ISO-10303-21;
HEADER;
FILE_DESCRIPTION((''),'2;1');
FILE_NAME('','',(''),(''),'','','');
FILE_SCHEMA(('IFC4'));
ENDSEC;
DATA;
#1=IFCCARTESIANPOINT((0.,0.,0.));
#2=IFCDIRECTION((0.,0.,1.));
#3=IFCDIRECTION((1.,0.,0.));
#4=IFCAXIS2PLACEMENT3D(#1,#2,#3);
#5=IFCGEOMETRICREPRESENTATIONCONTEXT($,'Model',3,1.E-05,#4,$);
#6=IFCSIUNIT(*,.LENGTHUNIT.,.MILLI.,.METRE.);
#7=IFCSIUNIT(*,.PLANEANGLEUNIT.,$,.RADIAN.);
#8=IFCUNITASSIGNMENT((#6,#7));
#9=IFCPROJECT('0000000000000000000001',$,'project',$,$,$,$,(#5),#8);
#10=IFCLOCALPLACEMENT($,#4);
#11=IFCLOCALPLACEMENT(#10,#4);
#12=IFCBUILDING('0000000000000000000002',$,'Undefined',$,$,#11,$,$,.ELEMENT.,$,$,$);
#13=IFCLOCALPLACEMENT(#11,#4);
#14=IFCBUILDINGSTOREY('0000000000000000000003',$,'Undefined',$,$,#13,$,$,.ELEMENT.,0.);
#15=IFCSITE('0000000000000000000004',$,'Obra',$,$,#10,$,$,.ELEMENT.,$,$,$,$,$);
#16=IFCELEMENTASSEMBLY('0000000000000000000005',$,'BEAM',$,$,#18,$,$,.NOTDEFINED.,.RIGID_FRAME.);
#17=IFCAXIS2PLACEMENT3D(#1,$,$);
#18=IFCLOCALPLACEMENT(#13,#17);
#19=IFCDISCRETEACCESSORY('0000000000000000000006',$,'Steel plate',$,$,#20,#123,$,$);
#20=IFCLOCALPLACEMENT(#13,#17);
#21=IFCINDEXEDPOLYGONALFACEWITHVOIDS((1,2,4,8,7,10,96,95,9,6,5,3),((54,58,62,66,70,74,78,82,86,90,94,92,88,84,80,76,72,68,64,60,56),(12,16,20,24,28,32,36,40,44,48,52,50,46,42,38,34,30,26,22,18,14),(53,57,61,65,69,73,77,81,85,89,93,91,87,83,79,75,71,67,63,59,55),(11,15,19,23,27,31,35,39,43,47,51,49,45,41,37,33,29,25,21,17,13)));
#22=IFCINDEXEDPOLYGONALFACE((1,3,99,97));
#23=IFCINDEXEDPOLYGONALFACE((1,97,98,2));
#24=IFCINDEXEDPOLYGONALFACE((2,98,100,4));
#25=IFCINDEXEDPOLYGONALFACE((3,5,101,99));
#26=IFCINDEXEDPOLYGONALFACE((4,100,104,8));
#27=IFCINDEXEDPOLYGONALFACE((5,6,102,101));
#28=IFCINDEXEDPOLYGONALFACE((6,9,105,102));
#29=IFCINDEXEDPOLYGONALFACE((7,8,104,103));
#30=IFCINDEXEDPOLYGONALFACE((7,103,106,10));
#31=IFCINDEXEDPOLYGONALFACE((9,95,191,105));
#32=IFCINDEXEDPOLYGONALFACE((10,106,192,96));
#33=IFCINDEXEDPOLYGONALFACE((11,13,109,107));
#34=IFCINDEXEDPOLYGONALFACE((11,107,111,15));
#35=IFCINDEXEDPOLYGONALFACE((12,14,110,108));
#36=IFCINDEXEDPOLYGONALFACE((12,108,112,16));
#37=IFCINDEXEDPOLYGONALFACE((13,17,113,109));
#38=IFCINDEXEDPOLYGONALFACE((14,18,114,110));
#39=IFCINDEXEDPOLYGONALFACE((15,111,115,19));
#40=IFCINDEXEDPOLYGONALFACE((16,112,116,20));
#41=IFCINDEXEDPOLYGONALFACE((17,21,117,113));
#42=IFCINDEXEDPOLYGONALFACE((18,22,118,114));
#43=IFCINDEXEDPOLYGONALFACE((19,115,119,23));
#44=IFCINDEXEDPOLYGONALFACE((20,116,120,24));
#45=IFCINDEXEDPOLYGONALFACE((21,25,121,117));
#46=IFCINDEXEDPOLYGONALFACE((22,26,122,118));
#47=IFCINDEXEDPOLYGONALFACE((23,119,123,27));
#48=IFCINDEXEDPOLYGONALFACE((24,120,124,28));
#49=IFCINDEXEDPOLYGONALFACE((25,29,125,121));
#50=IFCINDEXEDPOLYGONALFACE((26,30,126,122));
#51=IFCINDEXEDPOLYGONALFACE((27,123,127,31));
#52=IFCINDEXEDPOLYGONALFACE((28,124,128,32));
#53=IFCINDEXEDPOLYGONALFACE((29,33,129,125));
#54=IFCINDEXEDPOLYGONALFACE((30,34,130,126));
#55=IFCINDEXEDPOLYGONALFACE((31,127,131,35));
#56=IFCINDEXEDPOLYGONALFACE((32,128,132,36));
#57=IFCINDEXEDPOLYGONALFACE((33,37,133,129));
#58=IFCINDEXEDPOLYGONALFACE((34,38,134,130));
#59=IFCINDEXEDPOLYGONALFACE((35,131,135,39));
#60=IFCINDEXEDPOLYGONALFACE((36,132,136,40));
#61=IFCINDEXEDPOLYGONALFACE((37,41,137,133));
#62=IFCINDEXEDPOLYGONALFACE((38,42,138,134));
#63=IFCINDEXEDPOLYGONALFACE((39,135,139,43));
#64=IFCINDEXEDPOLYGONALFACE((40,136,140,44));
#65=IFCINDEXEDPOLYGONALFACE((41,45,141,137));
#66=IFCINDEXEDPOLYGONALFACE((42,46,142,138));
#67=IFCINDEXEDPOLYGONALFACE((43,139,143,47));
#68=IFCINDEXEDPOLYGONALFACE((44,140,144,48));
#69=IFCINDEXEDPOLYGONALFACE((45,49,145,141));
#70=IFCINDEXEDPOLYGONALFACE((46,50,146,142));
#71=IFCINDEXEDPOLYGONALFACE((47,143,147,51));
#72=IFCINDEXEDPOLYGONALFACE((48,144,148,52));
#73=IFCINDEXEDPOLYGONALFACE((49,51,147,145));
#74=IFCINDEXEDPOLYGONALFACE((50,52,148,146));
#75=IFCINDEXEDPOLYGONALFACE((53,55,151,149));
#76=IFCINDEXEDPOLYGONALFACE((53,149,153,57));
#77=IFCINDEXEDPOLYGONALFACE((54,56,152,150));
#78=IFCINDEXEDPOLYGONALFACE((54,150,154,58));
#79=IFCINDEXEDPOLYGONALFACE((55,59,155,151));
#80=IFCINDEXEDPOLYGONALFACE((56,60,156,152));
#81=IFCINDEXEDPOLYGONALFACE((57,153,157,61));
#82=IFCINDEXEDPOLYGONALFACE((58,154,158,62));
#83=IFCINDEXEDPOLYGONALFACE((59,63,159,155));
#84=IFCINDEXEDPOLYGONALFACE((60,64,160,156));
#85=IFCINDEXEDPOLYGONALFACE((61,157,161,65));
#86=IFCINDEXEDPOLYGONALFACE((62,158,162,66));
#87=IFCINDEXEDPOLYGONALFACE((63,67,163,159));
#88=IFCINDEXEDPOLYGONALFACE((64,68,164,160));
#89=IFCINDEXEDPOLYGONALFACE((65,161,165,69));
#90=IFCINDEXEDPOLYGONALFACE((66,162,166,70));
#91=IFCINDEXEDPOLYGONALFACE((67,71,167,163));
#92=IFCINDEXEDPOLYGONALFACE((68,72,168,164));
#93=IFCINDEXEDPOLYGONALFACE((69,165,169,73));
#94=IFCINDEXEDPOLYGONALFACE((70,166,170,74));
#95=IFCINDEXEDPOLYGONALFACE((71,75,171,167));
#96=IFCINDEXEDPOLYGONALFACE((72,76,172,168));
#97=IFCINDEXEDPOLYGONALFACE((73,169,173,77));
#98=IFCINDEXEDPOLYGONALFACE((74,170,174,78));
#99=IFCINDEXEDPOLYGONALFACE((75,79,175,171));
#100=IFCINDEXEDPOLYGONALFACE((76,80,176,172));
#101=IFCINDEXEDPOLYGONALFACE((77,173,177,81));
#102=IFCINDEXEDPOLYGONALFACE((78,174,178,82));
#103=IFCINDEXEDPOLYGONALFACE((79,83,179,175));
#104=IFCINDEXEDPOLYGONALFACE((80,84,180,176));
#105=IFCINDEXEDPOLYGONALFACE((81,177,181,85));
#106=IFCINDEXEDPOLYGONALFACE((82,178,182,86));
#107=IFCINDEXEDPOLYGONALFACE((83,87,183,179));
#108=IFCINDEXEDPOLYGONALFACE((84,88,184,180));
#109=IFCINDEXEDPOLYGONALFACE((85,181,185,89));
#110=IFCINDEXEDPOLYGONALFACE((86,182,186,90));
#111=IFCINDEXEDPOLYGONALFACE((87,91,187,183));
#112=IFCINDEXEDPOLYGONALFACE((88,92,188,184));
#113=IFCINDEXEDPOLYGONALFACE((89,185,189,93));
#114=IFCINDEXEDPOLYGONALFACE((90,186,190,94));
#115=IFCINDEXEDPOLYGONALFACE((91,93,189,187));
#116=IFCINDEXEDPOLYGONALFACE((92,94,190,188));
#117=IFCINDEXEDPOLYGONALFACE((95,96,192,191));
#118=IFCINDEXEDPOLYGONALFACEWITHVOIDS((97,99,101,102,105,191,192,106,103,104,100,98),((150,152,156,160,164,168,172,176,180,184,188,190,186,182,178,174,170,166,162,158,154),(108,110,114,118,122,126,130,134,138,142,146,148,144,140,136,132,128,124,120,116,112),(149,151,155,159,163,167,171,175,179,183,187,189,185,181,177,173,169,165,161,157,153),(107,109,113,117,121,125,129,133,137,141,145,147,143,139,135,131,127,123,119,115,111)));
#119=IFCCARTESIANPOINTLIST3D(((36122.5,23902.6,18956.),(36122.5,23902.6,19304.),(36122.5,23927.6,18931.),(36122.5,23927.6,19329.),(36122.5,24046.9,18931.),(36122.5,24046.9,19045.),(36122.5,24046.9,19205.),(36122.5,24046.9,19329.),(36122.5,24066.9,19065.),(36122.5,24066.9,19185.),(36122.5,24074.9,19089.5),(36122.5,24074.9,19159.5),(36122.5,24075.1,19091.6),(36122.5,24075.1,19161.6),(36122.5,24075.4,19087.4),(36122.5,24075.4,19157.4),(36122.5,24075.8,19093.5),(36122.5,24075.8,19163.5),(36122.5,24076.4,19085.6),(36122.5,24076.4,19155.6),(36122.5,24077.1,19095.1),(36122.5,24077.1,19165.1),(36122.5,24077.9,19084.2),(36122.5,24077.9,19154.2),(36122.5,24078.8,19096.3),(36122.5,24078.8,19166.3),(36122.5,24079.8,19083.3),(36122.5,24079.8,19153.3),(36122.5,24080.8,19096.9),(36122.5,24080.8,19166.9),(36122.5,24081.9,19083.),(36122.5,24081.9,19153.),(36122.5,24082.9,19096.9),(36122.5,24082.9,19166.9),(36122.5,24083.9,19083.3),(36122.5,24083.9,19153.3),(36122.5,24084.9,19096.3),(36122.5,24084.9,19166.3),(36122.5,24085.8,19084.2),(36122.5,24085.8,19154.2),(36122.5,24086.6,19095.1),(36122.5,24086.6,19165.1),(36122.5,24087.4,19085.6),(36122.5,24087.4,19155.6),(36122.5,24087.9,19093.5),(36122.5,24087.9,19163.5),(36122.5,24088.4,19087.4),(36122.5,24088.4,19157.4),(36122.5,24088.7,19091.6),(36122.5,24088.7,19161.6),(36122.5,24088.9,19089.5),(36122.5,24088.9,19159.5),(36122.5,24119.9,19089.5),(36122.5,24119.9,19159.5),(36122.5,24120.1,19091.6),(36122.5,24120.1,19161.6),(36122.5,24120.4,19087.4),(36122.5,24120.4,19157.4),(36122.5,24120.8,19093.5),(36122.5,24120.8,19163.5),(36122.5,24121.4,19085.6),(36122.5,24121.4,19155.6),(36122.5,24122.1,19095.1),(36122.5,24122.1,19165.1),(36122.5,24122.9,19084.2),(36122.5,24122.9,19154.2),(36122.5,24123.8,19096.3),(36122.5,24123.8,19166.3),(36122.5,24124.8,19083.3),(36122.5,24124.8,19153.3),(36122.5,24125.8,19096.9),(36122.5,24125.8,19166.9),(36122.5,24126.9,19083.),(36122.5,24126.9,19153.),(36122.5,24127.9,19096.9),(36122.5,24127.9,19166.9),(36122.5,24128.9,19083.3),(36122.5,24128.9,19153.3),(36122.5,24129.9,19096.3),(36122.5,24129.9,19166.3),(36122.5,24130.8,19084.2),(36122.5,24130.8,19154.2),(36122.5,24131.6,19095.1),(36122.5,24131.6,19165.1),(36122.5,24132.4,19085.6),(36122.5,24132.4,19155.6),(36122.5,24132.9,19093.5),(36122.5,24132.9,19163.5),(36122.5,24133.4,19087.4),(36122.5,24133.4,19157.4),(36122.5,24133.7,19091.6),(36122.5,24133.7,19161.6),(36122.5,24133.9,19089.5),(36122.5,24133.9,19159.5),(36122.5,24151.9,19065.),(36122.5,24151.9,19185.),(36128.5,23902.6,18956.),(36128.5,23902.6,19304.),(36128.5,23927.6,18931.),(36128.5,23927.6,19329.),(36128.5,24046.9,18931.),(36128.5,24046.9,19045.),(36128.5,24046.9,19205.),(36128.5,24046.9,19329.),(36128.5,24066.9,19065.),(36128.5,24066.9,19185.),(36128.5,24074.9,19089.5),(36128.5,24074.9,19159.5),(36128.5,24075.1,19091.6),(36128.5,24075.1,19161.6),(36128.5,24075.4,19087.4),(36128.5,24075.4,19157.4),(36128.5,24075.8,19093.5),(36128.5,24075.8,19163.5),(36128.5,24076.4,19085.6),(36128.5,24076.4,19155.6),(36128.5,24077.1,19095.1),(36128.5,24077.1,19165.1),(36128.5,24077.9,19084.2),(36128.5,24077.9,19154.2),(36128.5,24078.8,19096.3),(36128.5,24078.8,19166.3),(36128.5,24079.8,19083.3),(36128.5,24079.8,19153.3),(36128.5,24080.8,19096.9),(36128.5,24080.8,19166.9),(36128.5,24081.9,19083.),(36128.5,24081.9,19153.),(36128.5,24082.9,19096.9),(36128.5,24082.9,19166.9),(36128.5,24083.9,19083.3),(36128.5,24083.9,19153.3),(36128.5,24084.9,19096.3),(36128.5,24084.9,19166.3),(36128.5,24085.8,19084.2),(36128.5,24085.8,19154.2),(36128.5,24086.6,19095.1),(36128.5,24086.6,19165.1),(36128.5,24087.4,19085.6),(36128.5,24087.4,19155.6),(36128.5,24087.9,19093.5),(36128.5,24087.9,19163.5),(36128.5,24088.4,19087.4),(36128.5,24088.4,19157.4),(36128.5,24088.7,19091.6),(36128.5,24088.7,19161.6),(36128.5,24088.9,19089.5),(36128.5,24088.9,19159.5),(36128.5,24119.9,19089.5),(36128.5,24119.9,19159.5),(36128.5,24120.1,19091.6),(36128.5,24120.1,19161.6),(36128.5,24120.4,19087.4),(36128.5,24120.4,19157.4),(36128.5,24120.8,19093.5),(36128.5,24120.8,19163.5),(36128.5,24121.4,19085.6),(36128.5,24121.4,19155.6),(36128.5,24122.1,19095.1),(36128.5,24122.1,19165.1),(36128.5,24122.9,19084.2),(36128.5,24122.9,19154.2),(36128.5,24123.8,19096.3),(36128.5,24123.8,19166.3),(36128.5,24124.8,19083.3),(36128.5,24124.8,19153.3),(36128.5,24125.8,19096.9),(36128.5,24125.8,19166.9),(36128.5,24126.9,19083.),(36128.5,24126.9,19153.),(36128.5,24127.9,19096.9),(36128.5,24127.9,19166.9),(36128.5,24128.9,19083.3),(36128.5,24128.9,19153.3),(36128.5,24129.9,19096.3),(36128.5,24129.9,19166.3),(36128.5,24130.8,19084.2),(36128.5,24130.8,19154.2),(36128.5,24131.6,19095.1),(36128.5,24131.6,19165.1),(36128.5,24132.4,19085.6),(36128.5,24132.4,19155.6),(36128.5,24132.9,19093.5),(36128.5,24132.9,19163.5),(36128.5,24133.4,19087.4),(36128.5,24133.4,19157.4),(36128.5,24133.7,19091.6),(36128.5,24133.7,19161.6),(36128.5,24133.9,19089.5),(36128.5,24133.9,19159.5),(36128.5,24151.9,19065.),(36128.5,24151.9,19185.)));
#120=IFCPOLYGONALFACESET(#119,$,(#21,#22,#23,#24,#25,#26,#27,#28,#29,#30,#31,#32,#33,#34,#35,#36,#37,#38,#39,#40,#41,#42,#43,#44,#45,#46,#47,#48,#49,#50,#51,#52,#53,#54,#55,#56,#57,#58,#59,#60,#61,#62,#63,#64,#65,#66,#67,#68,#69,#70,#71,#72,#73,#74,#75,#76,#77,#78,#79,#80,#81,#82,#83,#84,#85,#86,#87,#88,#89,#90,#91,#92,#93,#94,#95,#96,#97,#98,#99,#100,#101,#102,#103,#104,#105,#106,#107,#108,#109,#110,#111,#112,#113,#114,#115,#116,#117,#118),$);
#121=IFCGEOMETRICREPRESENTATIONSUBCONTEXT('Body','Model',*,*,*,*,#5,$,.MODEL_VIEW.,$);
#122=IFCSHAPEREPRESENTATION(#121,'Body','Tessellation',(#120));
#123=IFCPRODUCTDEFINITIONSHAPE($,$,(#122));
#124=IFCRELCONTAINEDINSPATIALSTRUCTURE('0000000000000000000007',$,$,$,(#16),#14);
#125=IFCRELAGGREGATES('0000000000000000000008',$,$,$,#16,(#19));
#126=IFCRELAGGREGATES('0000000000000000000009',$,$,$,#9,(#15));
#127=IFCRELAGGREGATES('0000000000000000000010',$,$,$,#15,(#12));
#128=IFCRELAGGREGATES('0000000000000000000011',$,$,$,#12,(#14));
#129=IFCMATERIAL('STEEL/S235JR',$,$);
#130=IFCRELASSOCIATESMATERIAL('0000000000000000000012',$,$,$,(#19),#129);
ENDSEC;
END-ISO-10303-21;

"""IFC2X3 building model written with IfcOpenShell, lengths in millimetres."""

from ifc_helpers import new_model, si_unit, frame, origin_with_axes, origin_2d_with_axis, place, context, subcontext, project, spatial, polyline, circle, outline, extrude, source, transform, mapped, material, element, aggregate, save


model = new_model("IFC2X3")

# Units and contexts
model_context = context("Model", 3, precision=1e-05, world=origin_with_axes())
body_context = subcontext(model_context, "Body", "Model", "MODEL_VIEW")
ifc_project = project(units=[si_unit("LENGTHUNIT", "METRE", prefix="MILLI"), si_unit("PLANEANGLEUNIT", "RADIAN")], contexts=[model_context])

# Site, building, storey
site_placement = place(None, origin_with_axes())
site = spatial("IfcSite", under=ifc_project, at=site_placement, Name="Obra", CompositionType="ELEMENT")
building_placement = place(site_placement, origin_with_axes())
building = spatial("IfcBuilding", under=site, at=building_placement, Name="Undefined", CompositionType="ELEMENT")
storey_placement = place(building_placement, origin_with_axes())
storey = spatial("IfcBuildingStorey", under=building, at=storey_placement, Name="Undefined", CompositionType="ELEMENT", Elevation=0.0)

# Shared definitions
ifc_material_1 = material(Name="STEEL/S235JR")

# Element assembly
assembly_1_placement = place(storey_placement, origin_with_axes())
assembly_1 = element("IfcElementAssembly", 1, at=assembly_1_placement, inside=storey, Name="BEAM", AssemblyPlace="NOTDEFINED", PredefinedType="RIGID_FRAME")

# Shared definitions
shared_shape_1 = source(origin_with_axes(), body_context, "Body", "SweptSolid", [
    extrude(circle(Radius=7.0, at=origin_2d_with_axis()), frame((0.0, -8.6, 0.0), z_axis=(0.0, 1.0, 0.0), x_axis=(1.0, 0.0, 0.0)), (0.0, 0.0, 1.0), 6.2),
])

# Discrete accessory, opening
discrete_accessory_1_placement = place(assembly_1_placement, frame((36125.5, 23902.6, 18956.0), z_axis=(1.0, 0.0, 0.0), x_axis=(0.0, 0.707107, -0.707107)))
discrete_accessory_1 = element("IfcDiscreteAccessory", 2, at=discrete_accessory_1_placement, material=ifc_material_1, Name="Steel plate", context=body_context, shape_type="SweptSolid", body=[
    extrude(outline(polyline([(0.0, 0.0), (35.4, 0.0), (119.7, 84.3), (39.1, 164.9), (39.1, 193.2), (99.2, 253.3), (14.3, 338.2), (-45.8, 278.1), (-74.1, 278.1), (-161.8, 365.8), (-246.1, 281.4), (-246.1, 246.1), (0.0, 0.0)])), frame((0.0, 0.0, -3.0), z_axis=(0.0, 0.0, 1.0), x_axis=(1.0, 0.0, 0.0)), (0.0, 0.0, 1.0), 6.0),
])
opening_1_placement = place(assembly_1_placement, frame((36120.0, 24056.9, 19185.0), z_axis=(0.0, 1.0, 0.0), x_axis=(0.0, 0.0, -1.0)))
element("IfcOpeningElement", 3, at=opening_1_placement, cuts=discrete_accessory_1, ObjectType="Opening", context=body_context, shape_type="MappedRepresentation", body=[
    mapped(shared_shape_1, transform((25.0, 0.0, 25.0))),
    mapped(shared_shape_1, transform((25.0, 0.0, 70.0))),
    mapped(shared_shape_1, transform((95.0, 0.0, 25.0))),
    mapped(shared_shape_1, transform((95.0, 0.0, 70.0))),
])
aggregate(assembly_1, [discrete_accessory_1])

save(model, "model.ifc")
